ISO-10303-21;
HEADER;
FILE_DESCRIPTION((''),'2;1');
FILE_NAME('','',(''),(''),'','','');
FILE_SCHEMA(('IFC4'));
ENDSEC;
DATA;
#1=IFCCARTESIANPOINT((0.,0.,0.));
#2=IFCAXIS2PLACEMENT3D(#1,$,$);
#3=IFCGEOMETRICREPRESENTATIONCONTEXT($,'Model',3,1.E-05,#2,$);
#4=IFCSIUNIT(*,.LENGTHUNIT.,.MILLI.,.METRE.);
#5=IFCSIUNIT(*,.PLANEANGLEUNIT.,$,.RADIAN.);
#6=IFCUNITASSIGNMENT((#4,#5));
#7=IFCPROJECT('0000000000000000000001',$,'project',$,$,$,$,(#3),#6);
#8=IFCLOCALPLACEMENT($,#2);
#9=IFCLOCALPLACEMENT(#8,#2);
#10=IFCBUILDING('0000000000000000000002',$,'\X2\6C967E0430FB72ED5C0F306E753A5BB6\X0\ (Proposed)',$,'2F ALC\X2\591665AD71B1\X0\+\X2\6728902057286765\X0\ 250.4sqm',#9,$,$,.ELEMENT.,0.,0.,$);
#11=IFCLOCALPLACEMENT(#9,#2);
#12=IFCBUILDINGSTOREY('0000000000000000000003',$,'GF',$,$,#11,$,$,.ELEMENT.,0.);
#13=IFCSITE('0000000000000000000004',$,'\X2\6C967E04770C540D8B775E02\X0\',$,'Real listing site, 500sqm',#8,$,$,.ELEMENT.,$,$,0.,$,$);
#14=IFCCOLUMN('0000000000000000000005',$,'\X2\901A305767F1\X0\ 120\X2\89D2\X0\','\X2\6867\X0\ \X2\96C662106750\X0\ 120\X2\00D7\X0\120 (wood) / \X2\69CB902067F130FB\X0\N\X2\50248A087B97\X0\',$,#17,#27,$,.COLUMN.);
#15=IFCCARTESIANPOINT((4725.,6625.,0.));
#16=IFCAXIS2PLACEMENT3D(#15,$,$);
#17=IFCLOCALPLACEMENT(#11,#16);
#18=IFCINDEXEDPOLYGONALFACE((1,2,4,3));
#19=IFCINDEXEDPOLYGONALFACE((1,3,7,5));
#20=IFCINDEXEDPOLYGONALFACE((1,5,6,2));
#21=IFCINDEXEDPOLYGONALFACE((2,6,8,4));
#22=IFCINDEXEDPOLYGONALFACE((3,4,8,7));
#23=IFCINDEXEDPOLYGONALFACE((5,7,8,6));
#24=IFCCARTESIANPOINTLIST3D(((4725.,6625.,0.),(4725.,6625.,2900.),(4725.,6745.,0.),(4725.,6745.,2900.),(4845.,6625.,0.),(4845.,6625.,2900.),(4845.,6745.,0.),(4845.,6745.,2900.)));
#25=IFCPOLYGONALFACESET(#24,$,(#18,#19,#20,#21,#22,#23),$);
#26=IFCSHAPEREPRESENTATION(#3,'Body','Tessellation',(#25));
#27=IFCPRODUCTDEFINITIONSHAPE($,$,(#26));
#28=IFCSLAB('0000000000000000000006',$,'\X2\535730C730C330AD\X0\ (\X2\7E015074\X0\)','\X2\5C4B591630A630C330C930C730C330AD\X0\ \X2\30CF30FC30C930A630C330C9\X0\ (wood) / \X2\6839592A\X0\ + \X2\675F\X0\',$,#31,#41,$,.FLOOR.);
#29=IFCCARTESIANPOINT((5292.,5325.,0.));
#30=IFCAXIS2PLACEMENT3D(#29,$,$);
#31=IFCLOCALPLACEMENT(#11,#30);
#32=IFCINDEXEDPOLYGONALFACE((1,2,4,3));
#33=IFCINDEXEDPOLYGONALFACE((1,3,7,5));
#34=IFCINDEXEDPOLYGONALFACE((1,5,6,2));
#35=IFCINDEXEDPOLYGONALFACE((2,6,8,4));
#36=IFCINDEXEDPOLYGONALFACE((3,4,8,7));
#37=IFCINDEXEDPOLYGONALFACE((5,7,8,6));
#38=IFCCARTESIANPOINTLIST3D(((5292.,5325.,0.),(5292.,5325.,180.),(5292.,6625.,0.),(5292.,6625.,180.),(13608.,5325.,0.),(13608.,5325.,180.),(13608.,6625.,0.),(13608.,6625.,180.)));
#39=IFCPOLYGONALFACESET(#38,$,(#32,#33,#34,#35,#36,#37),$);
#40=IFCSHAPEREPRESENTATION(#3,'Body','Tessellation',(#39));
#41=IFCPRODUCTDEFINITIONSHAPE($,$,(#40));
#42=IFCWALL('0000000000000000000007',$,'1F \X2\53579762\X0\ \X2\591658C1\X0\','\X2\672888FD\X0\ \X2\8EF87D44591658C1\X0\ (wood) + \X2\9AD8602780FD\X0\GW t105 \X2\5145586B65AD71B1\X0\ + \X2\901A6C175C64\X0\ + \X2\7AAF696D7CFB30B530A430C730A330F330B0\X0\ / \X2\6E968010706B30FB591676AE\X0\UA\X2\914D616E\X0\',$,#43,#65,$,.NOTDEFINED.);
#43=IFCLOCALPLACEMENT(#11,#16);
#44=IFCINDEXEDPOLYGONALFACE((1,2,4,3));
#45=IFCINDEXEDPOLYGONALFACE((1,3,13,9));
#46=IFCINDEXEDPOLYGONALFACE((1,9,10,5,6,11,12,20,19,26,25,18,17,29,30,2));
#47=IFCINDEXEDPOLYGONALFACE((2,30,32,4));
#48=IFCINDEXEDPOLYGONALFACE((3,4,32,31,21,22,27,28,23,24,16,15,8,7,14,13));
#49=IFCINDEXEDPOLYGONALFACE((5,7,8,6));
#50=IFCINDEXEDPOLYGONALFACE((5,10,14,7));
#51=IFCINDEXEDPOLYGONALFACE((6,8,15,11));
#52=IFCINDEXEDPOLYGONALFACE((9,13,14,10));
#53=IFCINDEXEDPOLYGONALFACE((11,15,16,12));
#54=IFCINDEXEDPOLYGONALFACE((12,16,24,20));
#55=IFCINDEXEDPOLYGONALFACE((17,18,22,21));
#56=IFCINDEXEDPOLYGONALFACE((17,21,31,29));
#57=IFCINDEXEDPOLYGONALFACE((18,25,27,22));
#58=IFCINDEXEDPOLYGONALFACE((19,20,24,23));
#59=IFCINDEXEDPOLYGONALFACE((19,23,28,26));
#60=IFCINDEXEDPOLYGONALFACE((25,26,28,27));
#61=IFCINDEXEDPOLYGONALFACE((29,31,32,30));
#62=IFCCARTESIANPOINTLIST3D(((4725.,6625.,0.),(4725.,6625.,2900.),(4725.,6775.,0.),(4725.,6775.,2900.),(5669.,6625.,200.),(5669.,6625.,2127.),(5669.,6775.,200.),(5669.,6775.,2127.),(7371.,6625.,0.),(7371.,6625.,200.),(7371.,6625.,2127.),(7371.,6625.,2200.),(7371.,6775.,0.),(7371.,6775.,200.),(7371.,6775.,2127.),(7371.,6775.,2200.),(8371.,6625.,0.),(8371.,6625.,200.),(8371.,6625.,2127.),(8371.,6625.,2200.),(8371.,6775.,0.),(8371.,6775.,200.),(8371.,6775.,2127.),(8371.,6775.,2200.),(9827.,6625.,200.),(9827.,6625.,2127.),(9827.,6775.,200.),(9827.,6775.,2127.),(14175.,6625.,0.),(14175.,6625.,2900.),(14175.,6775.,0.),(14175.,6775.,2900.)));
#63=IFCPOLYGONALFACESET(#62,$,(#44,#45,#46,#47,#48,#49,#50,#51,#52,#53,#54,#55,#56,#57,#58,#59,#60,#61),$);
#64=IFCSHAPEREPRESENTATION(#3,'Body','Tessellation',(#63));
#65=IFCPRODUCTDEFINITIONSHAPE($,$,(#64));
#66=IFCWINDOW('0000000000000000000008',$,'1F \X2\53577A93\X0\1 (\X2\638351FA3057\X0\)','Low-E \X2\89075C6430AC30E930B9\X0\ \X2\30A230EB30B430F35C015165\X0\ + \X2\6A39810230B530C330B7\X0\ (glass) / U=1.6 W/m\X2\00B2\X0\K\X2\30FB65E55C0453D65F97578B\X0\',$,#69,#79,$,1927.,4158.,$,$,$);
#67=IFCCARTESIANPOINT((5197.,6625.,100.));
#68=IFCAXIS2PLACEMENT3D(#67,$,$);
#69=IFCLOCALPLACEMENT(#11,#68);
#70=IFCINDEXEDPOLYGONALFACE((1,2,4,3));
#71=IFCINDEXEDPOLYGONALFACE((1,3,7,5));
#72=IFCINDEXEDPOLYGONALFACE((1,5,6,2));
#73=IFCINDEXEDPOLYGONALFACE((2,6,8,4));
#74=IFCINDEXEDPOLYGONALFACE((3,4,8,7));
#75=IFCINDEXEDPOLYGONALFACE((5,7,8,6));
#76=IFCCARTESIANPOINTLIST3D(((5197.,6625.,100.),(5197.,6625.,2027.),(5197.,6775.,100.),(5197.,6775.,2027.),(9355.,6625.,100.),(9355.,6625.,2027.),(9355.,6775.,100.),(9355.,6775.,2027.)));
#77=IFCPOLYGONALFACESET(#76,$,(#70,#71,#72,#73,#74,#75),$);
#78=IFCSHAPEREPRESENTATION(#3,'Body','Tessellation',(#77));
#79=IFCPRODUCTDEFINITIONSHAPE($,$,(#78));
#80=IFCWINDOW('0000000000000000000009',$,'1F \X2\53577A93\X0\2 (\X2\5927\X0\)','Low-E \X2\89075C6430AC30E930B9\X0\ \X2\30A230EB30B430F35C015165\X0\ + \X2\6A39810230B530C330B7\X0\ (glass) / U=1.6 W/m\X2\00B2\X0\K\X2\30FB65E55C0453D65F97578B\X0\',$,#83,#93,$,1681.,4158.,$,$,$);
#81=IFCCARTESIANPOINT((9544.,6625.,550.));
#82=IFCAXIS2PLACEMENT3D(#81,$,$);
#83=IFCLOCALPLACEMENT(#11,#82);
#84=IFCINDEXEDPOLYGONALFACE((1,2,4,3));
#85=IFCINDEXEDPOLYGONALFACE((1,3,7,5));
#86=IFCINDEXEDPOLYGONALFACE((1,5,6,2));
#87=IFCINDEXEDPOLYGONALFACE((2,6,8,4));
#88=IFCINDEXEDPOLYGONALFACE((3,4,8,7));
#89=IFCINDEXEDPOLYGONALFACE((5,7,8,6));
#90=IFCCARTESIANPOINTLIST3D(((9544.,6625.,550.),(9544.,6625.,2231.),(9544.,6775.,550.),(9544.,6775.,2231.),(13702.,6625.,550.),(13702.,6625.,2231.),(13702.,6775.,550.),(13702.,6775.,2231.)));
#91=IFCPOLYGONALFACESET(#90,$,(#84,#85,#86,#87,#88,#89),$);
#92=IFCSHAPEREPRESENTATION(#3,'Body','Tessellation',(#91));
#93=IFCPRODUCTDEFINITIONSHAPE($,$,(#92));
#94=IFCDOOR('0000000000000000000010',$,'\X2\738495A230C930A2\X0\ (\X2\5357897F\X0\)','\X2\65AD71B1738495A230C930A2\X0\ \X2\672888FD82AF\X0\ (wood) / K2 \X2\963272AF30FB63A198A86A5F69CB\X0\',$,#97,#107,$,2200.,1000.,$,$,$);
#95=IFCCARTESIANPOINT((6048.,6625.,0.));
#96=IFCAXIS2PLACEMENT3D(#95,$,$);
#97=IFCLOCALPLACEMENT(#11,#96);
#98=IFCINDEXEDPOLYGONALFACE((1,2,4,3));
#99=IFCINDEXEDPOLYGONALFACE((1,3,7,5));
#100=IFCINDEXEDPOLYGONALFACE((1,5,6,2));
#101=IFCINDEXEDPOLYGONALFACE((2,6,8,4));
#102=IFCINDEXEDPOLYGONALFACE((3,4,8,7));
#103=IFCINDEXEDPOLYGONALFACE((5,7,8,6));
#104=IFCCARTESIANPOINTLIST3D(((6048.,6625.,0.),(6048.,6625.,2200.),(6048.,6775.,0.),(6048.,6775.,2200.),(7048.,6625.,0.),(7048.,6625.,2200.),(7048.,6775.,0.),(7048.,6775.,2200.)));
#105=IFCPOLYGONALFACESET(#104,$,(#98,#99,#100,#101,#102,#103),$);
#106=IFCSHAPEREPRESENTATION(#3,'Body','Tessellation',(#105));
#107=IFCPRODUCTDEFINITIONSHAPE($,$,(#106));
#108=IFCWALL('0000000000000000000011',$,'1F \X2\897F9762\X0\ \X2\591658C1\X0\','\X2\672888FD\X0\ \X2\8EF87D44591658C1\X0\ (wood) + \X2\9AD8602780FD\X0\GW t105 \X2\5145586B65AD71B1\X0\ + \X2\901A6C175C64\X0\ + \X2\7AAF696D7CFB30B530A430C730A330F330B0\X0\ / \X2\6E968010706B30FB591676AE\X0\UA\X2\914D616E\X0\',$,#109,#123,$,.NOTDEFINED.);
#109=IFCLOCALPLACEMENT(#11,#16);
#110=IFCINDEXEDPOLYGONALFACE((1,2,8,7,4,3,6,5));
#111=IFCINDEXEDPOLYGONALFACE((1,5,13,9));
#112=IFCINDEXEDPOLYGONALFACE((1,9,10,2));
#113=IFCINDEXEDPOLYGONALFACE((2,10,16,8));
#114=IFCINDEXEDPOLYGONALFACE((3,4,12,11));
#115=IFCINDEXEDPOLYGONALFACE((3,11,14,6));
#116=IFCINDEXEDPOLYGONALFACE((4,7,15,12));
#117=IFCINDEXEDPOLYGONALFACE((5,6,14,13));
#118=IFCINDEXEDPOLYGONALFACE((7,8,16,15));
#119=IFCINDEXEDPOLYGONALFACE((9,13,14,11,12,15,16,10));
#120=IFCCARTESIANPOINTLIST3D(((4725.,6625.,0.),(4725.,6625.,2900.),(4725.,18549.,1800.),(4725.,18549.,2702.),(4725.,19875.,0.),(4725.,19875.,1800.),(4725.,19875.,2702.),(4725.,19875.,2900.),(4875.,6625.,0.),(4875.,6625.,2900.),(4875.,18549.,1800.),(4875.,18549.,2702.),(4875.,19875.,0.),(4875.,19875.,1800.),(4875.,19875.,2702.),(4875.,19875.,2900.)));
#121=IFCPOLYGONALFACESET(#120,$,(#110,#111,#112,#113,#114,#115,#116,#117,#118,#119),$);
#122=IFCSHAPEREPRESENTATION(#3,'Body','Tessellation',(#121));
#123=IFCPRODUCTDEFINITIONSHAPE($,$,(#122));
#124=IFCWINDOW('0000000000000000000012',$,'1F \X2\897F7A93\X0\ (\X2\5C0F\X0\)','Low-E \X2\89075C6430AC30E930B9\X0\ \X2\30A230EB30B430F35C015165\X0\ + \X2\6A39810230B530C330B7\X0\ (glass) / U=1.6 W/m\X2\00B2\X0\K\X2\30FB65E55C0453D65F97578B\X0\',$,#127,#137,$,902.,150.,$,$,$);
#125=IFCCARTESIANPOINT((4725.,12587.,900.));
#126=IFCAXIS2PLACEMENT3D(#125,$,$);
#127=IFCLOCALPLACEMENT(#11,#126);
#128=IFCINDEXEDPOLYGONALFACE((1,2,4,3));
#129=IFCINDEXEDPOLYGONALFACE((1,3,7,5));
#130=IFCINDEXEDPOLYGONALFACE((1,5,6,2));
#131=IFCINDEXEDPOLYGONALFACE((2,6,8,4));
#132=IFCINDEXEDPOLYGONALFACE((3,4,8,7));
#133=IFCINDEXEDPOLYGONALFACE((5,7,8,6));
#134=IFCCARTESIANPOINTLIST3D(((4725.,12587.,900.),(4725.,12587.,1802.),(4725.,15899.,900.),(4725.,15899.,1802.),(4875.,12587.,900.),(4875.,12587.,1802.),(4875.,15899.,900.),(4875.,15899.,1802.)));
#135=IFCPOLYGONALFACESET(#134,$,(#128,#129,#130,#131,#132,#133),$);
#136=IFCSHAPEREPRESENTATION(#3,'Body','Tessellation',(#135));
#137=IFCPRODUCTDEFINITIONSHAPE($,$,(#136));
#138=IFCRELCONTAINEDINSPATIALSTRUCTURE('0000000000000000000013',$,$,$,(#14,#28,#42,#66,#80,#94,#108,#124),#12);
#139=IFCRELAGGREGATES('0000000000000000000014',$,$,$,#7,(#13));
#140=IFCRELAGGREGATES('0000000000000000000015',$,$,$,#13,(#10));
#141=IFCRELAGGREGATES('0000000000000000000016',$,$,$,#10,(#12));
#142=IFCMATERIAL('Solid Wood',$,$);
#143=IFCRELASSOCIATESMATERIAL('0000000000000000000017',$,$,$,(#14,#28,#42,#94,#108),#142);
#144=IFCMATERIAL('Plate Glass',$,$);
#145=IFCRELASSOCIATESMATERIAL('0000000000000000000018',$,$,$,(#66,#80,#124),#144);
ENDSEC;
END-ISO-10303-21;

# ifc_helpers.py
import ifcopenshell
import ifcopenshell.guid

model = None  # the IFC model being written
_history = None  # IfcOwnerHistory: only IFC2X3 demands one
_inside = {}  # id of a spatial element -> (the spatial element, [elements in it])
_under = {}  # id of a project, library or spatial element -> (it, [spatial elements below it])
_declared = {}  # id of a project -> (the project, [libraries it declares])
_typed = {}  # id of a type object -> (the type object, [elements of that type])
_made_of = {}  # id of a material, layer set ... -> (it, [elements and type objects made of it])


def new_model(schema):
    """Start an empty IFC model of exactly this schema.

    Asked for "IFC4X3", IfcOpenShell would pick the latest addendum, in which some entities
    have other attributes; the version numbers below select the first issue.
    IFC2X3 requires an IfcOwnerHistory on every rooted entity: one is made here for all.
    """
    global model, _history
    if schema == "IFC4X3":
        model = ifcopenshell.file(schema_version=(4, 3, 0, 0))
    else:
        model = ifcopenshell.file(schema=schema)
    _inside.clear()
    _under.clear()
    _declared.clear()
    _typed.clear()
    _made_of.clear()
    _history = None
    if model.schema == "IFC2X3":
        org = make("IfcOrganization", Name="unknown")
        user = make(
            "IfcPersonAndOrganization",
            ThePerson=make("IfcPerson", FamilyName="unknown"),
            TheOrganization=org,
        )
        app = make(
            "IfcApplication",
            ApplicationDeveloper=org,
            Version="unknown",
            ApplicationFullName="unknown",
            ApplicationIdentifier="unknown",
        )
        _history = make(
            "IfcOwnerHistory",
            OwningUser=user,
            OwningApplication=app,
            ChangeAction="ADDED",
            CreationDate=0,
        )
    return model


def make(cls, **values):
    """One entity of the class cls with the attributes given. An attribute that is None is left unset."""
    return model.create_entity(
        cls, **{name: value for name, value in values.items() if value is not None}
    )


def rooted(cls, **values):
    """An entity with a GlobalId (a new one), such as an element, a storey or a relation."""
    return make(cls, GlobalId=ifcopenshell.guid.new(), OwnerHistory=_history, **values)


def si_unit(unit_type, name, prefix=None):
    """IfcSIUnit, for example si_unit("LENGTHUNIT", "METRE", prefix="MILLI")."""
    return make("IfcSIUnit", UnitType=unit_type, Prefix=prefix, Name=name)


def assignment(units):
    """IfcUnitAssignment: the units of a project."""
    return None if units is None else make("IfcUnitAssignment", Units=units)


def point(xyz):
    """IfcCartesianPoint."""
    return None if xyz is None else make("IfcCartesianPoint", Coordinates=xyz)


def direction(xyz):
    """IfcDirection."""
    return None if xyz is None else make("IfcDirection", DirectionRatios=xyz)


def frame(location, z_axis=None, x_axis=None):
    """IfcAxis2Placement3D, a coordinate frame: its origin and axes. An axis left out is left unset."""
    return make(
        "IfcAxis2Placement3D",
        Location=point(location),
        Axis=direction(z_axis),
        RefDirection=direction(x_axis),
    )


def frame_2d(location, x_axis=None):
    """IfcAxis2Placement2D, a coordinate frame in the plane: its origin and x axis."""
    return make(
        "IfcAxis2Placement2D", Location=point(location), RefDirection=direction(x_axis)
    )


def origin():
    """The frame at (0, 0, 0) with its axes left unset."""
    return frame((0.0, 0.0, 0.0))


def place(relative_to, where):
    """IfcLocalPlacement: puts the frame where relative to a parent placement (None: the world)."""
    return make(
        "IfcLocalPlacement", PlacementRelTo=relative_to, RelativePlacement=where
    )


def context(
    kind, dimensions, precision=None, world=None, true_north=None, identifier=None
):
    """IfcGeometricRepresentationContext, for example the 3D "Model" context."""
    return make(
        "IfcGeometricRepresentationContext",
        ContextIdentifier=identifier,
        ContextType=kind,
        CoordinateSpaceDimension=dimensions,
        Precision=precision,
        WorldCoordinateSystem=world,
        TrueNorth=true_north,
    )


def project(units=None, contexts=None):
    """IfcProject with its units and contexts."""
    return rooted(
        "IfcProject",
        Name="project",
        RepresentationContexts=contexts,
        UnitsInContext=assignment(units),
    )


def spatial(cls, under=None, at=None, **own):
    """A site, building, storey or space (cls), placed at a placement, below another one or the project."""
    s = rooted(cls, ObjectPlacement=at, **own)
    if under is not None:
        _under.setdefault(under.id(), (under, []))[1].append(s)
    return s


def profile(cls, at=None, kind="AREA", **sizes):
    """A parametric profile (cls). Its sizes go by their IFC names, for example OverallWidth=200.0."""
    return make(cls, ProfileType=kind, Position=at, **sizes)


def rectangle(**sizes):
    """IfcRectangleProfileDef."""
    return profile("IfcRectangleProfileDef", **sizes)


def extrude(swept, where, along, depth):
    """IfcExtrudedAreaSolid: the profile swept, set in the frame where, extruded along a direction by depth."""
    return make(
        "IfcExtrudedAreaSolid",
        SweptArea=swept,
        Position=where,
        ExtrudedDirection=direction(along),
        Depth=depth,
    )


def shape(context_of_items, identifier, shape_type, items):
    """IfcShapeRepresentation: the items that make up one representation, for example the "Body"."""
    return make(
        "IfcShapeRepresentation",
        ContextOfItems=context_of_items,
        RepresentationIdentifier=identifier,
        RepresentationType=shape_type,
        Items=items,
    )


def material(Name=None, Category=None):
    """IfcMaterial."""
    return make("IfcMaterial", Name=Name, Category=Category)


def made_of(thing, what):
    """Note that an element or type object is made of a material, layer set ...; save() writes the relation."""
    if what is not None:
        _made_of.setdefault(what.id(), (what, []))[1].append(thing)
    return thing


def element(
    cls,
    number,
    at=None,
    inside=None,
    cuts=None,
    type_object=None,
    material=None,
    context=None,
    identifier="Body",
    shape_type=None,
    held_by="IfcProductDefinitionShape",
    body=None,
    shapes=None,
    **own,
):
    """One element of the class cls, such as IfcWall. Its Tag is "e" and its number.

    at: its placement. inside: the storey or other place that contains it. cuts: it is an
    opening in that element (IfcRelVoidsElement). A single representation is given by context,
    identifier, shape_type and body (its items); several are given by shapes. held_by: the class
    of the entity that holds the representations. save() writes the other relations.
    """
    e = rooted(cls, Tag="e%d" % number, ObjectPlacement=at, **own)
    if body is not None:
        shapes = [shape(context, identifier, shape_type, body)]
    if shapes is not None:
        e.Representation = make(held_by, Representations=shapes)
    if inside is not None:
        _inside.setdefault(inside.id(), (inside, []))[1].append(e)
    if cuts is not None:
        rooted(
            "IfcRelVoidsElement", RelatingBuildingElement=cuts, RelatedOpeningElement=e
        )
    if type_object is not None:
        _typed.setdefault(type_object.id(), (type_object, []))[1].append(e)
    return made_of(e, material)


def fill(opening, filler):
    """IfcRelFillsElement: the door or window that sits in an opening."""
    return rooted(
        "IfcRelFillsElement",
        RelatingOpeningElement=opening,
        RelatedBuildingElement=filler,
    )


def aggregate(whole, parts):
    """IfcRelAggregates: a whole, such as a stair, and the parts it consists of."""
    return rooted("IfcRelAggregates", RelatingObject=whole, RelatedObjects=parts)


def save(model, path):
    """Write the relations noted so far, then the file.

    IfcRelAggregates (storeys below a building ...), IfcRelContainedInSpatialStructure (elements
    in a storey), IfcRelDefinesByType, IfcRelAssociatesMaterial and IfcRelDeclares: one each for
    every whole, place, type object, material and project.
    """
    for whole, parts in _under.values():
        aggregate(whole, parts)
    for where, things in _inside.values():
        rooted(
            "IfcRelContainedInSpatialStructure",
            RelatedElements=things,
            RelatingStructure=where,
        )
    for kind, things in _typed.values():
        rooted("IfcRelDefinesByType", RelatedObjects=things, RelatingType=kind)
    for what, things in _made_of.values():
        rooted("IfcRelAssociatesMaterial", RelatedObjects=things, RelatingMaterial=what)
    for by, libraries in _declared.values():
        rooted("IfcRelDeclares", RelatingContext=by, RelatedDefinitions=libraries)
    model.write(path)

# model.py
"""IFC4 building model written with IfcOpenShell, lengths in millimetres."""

from ifc_helpers import new_model, si_unit, frame, frame_2d, origin, place, context, project, spatial, rectangle, extrude, material, element, fill, save


model = new_model("IFC4")

# Units and contexts
model_context = context("Model", 3, precision=1e-05, world=origin())
ifc_project = project(units=[si_unit("LENGTHUNIT", "METRE", prefix="MILLI"), si_unit("PLANEANGLEUNIT", "RADIAN")], contexts=[model_context])

# Site, building, storey
site_placement = place(None, origin())
site = spatial("IfcSite", under=ifc_project, at=site_placement, Name="沖縄県名護市", ObjectType="Real listing site, 500sqm", CompositionType="ELEMENT", RefElevation=0.0)
building_placement = place(site_placement, origin())
building = spatial("IfcBuilding", under=site, at=building_placement, Name="沖縄・狭小の町家 (Proposed)", ObjectType="2F ALC外断熱+木造在来 250.4sqm", CompositionType="ELEMENT", ElevationOfRefHeight=0.0, ElevationOfTerrain=0.0)
storey_placement = place(building_placement, origin())
storey = spatial("IfcBuildingStorey", under=building, at=storey_placement, Name="GF", CompositionType="ELEMENT", Elevation=0.0)

# Column
ifc_material_1 = material(Name="Solid Wood")
column_placement = place(storey_placement, frame((4725.0, 6625.0, 0.0)))
element("IfcColumn", 1, at=column_placement, inside=storey, material=ifc_material_1, Name="通し柱 120角", Description="桧 集成材 120×120 (wood) / 構造柱・N値計算", PredefinedType="COLUMN", context=model_context, shape_type="SweptSolid", body=[
    extrude(rectangle(XDim=120.0, YDim=120.0, at=frame_2d((60.0, 60.0))), frame((4725.0, 6625.0, 0.0)), (0.0, 0.0, 1.0), 2900.0),
])

# Slab
slab_1_placement = place(storey_placement, frame((5292.0, 5325.0, 0.0)))
element("IfcSlab", 2, at=slab_1_placement, inside=storey, material=ifc_material_1, Name="南デッキ (縁側)", Description="屋外ウッドデッキ ハードウッド (wood) / 根太 + 束", PredefinedType="FLOOR", context=model_context, shape_type="SweptSolid", body=[
    extrude(rectangle(XDim=8316.0, YDim=1300.0, at=frame_2d((4158.0, 650.0))), frame((5292.0, 5325.0, 0.0)), (0.0, 0.0, 1.0), 180.0),
])

# Wall, openings, windows, door
wall_1_placement = place(storey_placement, frame((4725.0, 6625.0, 0.0)))
wall_1 = element("IfcWall", 3, at=wall_1_placement, inside=storey, material=ifc_material_1, Name="1F 南面 外壁", Description="木製 軸組外壁 (wood) + 高性能GW t105 充填断熱 + 通気層 + 窯業系サイディング / 準耐火・外皮UA配慮", PredefinedType="NOTDEFINED", context=model_context, shape_type="SweptSolid", body=[
    extrude(rectangle(XDim=9450.0, YDim=150.0, at=frame_2d((4725.0, 75.0))), frame((4725.0, 6625.0, 0.0)), (0.0, 0.0, 1.0), 2900.0),
])
opening_1_placement = place(storey_placement, frame((5197.0, 6625.0, 100.0)))
opening_1 = element("IfcOpeningElement", 4, at=opening_1_placement, cuts=wall_1, PredefinedType="NOTDEFINED", context=model_context, shape_type="SweptSolid", body=[
    extrude(rectangle(XDim=4158.0, YDim=150.0, at=frame_2d((2079.0, 75.0))), frame((5197.0, 6625.0, 100.0)), (0.0, 0.0, 1.0), 1927.0),
])
opening_2_placement = place(storey_placement, frame((9544.0, 6625.0, 550.0)))
opening_2 = element("IfcOpeningElement", 5, at=opening_2_placement, cuts=wall_1, PredefinedType="NOTDEFINED", context=model_context, shape_type="SweptSolid", body=[
    extrude(rectangle(XDim=4158.0, YDim=150.0, at=frame_2d((2079.0, 75.0))), frame((9544.0, 6625.0, 550.0)), (0.0, 0.0, 1.0), 1681.0),
])
opening_3_placement = place(storey_placement, frame((6048.0, 6625.0, 0.0)))
opening_3 = element("IfcOpeningElement", 6, at=opening_3_placement, cuts=wall_1, PredefinedType="NOTDEFINED", context=model_context, shape_type="SweptSolid", body=[
    extrude(rectangle(XDim=1000.0, YDim=150.0, at=frame_2d((500.0, 75.0))), frame((6048.0, 6625.0, 0.0)), (0.0, 0.0, 1.0), 2200.0),
])
ifc_material_2 = material(Name="Plate Glass")
window_1_placement = place(storey_placement, frame((5197.0, 6625.0, 100.0)))
window_1 = element("IfcWindow", 7, at=window_1_placement, inside=storey, material=ifc_material_2, Name="1F 南窓1 (掃出し)", Description="Low-E 複層ガラス アルゴン封入 + 樹脂サッシ (glass) / U=1.6 W/m²K・日射取得型", OverallHeight=1927.0, OverallWidth=4158.0, context=model_context, shape_type="SweptSolid", body=[
    extrude(rectangle(XDim=4158.0, YDim=150.0, at=frame_2d((2079.0, 75.0))), frame((5197.0, 6625.0, 100.0)), (0.0, 0.0, 1.0), 1927.0),
])
fill(opening_1, window_1)
window_2_placement = place(storey_placement, frame((9544.0, 6625.0, 550.0)))
window_2 = element("IfcWindow", 8, at=window_2_placement, inside=storey, material=ifc_material_2, Name="1F 南窓2 (大)", Description="Low-E 複層ガラス アルゴン封入 + 樹脂サッシ (glass) / U=1.6 W/m²K・日射取得型", OverallHeight=1681.0, OverallWidth=4158.0, context=model_context, shape_type="SweptSolid", body=[
    extrude(rectangle(XDim=4158.0, YDim=150.0, at=frame_2d((2079.0, 75.0))), frame((9544.0, 6625.0, 550.0)), (0.0, 0.0, 1.0), 1681.0),
])
fill(opening_2, window_2)
door_placement = place(storey_placement, frame((6048.0, 6625.0, 0.0)))
door = element("IfcDoor", 9, at=door_placement, inside=storey, material=ifc_material_1, Name="玄関ドア (南西)", Description="断熱玄関ドア 木製芯 (wood) / K2 防犯・採風機構", OverallHeight=2200.0, OverallWidth=1000.0, context=model_context, shape_type="SweptSolid", body=[
    extrude(rectangle(XDim=1000.0, YDim=150.0, at=frame_2d((500.0, 75.0))), frame((6048.0, 6625.0, 0.0)), (0.0, 0.0, 1.0), 2200.0),
])
fill(opening_3, door)

# Wall, opening, window
wall_2_placement = place(storey_placement, frame((4725.0, 6625.0, 0.0)))
wall_2 = element("IfcWall", 10, at=wall_2_placement, inside=storey, material=ifc_material_1, Name="1F 西面 外壁", Description="木製 軸組外壁 (wood) + 高性能GW t105 充填断熱 + 通気層 + 窯業系サイディング / 準耐火・外皮UA配慮", PredefinedType="NOTDEFINED", context=model_context, shape_type="SweptSolid", body=[
    extrude(rectangle(XDim=150.0, YDim=13250.0, at=frame_2d((75.0, 6625.0))), frame((4725.0, 6625.0, 0.0)), (0.0, 0.0, 1.0), 2900.0),
])
opening_4_placement = place(storey_placement, frame((4725.0, 12587.0, 900.0)))
opening_4 = element("IfcOpeningElement", 11, at=opening_4_placement, cuts=wall_2, PredefinedType="NOTDEFINED", context=model_context, shape_type="SweptSolid", body=[
    extrude(rectangle(XDim=150.0, YDim=3312.0, at=frame_2d((75.0, 1656.0))), frame((4725.0, 12587.0, 900.0)), (0.0, 0.0, 1.0), 902.0),
])
window_3_placement = place(storey_placement, frame((4725.0, 12587.0, 900.0)))
window_3 = element("IfcWindow", 12, at=window_3_placement, inside=storey, material=ifc_material_2, Name="1F 西窓 (小)", Description="Low-E 複層ガラス アルゴン封入 + 樹脂サッシ (glass) / U=1.6 W/m²K・日射取得型", OverallHeight=902.0, OverallWidth=150.0, context=model_context, shape_type="SweptSolid", body=[
    extrude(rectangle(XDim=150.0, YDim=3312.0, at=frame_2d((75.0, 1656.0))), frame((4725.0, 12587.0, 900.0)), (0.0, 0.0, 1.0), 902.0),
])
fill(opening_4, window_3)

save(model, "model.ifc")
